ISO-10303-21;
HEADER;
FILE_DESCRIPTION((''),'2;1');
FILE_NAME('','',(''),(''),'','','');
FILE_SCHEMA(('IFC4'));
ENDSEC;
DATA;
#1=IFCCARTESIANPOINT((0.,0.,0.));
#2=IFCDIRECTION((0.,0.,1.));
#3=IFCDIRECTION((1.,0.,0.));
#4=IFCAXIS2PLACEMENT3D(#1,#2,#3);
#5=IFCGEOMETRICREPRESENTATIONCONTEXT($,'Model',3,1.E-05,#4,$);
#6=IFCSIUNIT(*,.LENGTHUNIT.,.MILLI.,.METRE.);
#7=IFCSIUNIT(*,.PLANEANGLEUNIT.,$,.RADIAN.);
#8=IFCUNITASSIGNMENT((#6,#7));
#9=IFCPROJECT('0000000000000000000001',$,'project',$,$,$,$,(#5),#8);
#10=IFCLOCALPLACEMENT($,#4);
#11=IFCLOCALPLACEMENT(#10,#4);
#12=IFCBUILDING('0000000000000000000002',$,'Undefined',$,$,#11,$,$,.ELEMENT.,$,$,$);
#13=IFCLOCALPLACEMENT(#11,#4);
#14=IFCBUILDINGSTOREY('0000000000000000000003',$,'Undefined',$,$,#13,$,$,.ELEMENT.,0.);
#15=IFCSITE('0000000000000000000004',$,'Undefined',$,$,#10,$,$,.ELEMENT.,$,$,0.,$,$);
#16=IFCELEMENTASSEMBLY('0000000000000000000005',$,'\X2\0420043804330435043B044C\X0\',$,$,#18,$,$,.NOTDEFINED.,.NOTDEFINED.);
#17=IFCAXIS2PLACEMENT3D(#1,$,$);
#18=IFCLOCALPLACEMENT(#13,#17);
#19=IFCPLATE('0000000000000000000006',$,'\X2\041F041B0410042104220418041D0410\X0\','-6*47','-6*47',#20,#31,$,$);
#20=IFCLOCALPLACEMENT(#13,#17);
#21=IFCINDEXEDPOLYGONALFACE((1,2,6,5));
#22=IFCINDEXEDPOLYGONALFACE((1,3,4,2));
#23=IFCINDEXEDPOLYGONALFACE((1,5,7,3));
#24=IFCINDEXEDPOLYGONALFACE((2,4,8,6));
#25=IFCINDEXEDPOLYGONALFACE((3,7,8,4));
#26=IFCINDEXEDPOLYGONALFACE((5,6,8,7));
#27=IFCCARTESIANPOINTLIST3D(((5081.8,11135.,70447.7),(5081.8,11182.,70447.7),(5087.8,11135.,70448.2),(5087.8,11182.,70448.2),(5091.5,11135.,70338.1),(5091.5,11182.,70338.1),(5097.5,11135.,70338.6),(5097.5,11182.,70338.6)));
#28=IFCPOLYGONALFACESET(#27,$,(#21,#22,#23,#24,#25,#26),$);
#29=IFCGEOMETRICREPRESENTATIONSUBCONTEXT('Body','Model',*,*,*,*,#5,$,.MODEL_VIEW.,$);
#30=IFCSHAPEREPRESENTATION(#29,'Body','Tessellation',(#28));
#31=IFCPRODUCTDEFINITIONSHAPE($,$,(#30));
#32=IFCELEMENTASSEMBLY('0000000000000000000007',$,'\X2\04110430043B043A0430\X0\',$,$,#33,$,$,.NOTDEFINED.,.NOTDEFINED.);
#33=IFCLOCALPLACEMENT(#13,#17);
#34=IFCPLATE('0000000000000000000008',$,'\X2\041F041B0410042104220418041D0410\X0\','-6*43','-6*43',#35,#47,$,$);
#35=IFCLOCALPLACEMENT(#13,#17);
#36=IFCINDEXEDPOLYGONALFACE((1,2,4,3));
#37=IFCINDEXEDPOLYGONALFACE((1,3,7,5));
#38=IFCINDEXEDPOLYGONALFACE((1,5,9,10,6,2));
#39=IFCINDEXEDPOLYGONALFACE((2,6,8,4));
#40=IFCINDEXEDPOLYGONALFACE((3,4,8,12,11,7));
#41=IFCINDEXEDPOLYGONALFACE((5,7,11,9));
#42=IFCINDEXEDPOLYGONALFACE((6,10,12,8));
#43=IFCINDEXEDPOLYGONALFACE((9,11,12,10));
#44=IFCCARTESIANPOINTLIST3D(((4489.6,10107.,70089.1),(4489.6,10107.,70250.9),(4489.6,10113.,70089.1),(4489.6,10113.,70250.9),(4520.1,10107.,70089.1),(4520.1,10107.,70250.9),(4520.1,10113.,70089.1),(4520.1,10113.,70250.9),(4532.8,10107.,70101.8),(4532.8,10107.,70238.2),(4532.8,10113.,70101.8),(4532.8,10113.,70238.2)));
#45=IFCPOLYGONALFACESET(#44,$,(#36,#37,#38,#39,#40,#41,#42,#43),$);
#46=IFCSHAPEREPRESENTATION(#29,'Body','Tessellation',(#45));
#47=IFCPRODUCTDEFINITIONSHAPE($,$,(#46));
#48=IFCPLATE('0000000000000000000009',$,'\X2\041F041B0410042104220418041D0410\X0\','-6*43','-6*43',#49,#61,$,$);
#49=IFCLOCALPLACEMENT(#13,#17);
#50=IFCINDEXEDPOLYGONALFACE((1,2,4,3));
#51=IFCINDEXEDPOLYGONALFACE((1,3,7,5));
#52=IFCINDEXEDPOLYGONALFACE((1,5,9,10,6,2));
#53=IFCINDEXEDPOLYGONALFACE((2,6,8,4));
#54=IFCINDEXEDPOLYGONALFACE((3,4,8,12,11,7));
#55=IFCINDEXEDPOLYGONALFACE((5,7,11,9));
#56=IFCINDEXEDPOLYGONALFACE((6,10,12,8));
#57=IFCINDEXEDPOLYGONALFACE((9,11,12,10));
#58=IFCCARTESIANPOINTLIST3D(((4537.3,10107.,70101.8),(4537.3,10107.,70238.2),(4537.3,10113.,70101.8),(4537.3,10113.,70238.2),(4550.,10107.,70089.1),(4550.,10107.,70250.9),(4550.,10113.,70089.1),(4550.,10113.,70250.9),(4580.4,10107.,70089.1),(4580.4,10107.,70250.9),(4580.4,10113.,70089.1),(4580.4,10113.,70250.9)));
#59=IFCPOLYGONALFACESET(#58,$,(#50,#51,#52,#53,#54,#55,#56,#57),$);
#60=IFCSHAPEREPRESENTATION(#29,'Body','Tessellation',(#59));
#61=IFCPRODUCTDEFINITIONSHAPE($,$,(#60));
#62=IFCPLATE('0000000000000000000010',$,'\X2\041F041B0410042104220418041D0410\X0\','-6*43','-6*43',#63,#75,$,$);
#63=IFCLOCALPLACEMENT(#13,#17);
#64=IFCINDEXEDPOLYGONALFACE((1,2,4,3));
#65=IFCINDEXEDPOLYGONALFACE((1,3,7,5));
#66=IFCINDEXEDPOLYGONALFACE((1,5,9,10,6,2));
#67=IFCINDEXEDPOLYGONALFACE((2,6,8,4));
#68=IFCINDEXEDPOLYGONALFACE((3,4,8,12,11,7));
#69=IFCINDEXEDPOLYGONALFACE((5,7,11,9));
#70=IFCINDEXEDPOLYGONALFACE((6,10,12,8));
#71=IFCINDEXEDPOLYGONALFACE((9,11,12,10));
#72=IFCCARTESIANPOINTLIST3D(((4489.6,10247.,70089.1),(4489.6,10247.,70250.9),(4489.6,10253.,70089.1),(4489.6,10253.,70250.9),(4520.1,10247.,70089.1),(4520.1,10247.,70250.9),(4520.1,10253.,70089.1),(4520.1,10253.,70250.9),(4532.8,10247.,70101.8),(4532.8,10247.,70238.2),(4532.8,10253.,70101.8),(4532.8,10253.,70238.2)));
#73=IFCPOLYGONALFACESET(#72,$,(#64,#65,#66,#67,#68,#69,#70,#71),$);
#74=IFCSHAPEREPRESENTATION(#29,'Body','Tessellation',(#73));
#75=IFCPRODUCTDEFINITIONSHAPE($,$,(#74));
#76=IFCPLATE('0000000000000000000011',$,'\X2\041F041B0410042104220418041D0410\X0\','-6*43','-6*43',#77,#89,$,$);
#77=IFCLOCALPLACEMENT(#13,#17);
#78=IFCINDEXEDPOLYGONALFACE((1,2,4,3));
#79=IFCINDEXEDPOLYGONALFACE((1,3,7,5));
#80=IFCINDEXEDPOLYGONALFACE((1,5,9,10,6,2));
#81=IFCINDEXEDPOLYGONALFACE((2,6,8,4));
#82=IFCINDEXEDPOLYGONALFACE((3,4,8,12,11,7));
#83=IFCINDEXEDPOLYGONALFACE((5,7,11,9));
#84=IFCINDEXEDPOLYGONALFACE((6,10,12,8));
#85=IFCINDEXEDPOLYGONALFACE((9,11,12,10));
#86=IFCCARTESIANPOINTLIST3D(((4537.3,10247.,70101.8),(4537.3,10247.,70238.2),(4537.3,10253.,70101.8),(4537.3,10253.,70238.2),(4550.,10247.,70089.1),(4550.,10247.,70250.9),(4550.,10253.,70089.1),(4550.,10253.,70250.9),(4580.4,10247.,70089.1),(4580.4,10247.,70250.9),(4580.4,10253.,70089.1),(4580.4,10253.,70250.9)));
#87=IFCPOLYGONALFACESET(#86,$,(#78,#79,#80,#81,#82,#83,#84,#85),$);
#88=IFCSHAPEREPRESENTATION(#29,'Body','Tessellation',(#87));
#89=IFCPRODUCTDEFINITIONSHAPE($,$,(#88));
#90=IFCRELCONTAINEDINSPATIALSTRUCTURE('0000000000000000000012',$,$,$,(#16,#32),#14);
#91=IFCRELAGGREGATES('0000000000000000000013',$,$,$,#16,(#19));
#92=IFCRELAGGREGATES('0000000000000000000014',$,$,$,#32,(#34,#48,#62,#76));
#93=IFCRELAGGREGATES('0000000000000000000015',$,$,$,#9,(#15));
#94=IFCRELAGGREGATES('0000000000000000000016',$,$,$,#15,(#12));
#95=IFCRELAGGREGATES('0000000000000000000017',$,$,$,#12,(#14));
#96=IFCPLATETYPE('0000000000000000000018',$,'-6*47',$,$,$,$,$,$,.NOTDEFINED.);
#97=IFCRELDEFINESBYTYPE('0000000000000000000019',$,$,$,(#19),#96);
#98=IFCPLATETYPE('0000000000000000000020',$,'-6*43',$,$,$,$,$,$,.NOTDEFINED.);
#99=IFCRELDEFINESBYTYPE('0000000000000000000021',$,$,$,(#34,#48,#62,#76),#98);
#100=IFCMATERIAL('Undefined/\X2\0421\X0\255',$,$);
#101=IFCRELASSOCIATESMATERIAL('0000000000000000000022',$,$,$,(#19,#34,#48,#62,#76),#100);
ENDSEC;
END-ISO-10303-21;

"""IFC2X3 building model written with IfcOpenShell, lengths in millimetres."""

from ifc_helpers import new_model, si_unit, frame, origin_with_axes, origin_2d_with_axis, place, context, subcontext, project, spatial, polyline, rectangle, outline, extrude, boolean, material, type_object, element, aggregate, save


model = new_model("IFC2X3")

# Units and contexts
model_context = context("Model", 3, precision=1e-05, world=origin_with_axes())
body_context = subcontext(model_context, "Body", "Model", "MODEL_VIEW")
ifc_project = project(units=[si_unit("LENGTHUNIT", "METRE", prefix="MILLI"), si_unit("PLANEANGLEUNIT", "RADIAN")], contexts=[model_context])

# Site, building, storey
site_placement = place(None, origin_with_axes())
site = spatial("IfcSite", under=ifc_project, at=site_placement, Name="Undefined", CompositionType="ELEMENT", RefElevation=0.0)
building_placement = place(site_placement, origin_with_axes())
building = spatial("IfcBuilding", under=site, at=building_placement, Name="Undefined", CompositionType="ELEMENT")
storey_placement = place(building_placement, origin_with_axes())
storey = spatial("IfcBuildingStorey", under=building, at=storey_placement, Name="Undefined", CompositionType="ELEMENT", Elevation=0.0)

# Shared definitions
ifc_material_1 = material(Name="Undefined/С255")

# Element assembly
assembly_1_placement = place(storey_placement, origin_with_axes())
assembly_1 = element("IfcElementAssembly", 1, at=assembly_1_placement, inside=storey, Name="Ригель", AssemblyPlace="NOTDEFINED", PredefinedType="NOTDEFINED")

# Plate
plate_type_1 = type_object("IfcPlateType", Name="-6*47", PredefinedType="NOTDEFINED")
plate_1_placement = place(assembly_1_placement, frame((5084.8, 11135.0, 70447.9), z_axis=(0.996107, 0.0, 0.088152), x_axis=(0.088152, 0.0, -0.996107)))
plate_1 = element("IfcPlate", 2, at=plate_1_placement, type_object=plate_type_1, material=ifc_material_1, Name="ПЛАСТИНА", Description="-6*47", ObjectType="-6*47", context=body_context, shape_type="CSG", body=[
    boolean("DIFFERENCE", extrude(outline(polyline([(0.0, 0.0), (110.0, 0.0), (110.0, 110.0), (0.0, 110.0), (0.0, 0.0)])), frame((0.0, 0.0, -3.0), z_axis=(0.0, 0.0, 1.0), x_axis=(1.0, 0.0, 0.0)), (0.0, 0.0, 1.0), 6.0), extrude(rectangle(XDim=26.0, YDim=130.0, at=origin_2d_with_axis()), frame((55.0, 47.0, 0.0), z_axis=(0.0, 1.0, 0.0), x_axis=(0.0, 0.0, -1.0)), (0.0, 0.0, 1.0), 66.0)),
])

# Element assembly, plates
assembly_2_placement = place(storey_placement, origin_with_axes())
assembly_2 = element("IfcElementAssembly", 3, at=assembly_2_placement, inside=storey, Name="Балка", AssemblyPlace="NOTDEFINED", PredefinedType="NOTDEFINED")
plate_type_2 = type_object("IfcPlateType", Name="-6*43", PredefinedType="NOTDEFINED")
plate_2_placement = place(assembly_2_placement, frame((4532.8, 10110.0, 70250.9), z_axis=(0.0, -1.0, 0.0), x_axis=(-1.0, 0.0, 0.0)))
plate_2 = element("IfcPlate", 4, at=plate_2_placement, type_object=plate_type_2, material=ifc_material_1, Name="ПЛАСТИНА", Description="-6*43", ObjectType="-6*43", context=body_context, shape_type="SweptSolid", body=[
    extrude(outline(polyline([(0.0, 12.7), (12.7, 0.0), (43.2, 0.0), (43.2, 161.8), (12.7, 161.8), (0.0, 149.1), (0.0, 12.7)])), frame((0.0, 0.0, -3.0), z_axis=(0.0, 0.0, 1.0), x_axis=(1.0, 0.0, 0.0)), (0.0, 0.0, 1.0), 6.0),
])
plate_3_placement = place(assembly_2_placement, frame((4580.4, 10110.0, 70250.9), z_axis=(0.0, -1.0, 0.0), x_axis=(-1.0, 0.0, 0.0)))
plate_3 = element("IfcPlate", 5, at=plate_3_placement, type_object=plate_type_2, material=ifc_material_1, Name="ПЛАСТИНА", Description="-6*43", ObjectType="-6*43", context=body_context, shape_type="SweptSolid", body=[
    extrude(outline(polyline([(0.0, 0.0), (30.5, 0.0), (43.2, 12.7), (43.2, 149.1), (30.5, 161.8), (0.0, 161.8), (0.0, 0.0)])), frame((0.0, 0.0, -3.0), z_axis=(0.0, 0.0, 1.0), x_axis=(1.0, 0.0, 0.0)), (0.0, 0.0, 1.0), 6.0),
])
plate_4_placement = place(assembly_2_placement, frame((4532.8, 10250.0, 70250.9), z_axis=(0.0, -1.0, 0.0), x_axis=(-1.0, 0.0, 0.0)))
plate_4 = element("IfcPlate", 6, at=plate_4_placement, type_object=plate_type_2, material=ifc_material_1, Name="ПЛАСТИНА", Description="-6*43", ObjectType="-6*43", context=body_context, shape_type="SweptSolid", body=[
    extrude(outline(polyline([(0.0, 12.7), (12.7, 0.0), (43.2, 0.0), (43.2, 161.8), (12.7, 161.8), (0.0, 149.1), (0.0, 12.7)])), frame((0.0, 0.0, -3.0), z_axis=(0.0, 0.0, 1.0), x_axis=(1.0, 0.0, 0.0)), (0.0, 0.0, 1.0), 6.0),
])
plate_5_placement = place(assembly_2_placement, frame((4580.4, 10250.0, 70250.9), z_axis=(0.0, -1.0, 0.0), x_axis=(-1.0, 0.0, 0.0)))
plate_5 = element("IfcPlate", 7, at=plate_5_placement, type_object=plate_type_2, material=ifc_material_1, Name="ПЛАСТИНА", Description="-6*43", ObjectType="-6*43", context=body_context, shape_type="SweptSolid", body=[
    extrude(outline(polyline([(0.0, 0.0), (30.5, 0.0), (43.2, 12.7), (43.2, 149.1), (30.5, 161.8), (0.0, 161.8), (0.0, 0.0)])), frame((0.0, 0.0, -3.0), z_axis=(0.0, 0.0, 1.0), x_axis=(1.0, 0.0, 0.0)), (0.0, 0.0, 1.0), 6.0),
])

aggregate(assembly_1, [plate_1])
aggregate(assembly_2, [plate_2, plate_3, plate_4, plate_5])

save(model, "model.ifc")
